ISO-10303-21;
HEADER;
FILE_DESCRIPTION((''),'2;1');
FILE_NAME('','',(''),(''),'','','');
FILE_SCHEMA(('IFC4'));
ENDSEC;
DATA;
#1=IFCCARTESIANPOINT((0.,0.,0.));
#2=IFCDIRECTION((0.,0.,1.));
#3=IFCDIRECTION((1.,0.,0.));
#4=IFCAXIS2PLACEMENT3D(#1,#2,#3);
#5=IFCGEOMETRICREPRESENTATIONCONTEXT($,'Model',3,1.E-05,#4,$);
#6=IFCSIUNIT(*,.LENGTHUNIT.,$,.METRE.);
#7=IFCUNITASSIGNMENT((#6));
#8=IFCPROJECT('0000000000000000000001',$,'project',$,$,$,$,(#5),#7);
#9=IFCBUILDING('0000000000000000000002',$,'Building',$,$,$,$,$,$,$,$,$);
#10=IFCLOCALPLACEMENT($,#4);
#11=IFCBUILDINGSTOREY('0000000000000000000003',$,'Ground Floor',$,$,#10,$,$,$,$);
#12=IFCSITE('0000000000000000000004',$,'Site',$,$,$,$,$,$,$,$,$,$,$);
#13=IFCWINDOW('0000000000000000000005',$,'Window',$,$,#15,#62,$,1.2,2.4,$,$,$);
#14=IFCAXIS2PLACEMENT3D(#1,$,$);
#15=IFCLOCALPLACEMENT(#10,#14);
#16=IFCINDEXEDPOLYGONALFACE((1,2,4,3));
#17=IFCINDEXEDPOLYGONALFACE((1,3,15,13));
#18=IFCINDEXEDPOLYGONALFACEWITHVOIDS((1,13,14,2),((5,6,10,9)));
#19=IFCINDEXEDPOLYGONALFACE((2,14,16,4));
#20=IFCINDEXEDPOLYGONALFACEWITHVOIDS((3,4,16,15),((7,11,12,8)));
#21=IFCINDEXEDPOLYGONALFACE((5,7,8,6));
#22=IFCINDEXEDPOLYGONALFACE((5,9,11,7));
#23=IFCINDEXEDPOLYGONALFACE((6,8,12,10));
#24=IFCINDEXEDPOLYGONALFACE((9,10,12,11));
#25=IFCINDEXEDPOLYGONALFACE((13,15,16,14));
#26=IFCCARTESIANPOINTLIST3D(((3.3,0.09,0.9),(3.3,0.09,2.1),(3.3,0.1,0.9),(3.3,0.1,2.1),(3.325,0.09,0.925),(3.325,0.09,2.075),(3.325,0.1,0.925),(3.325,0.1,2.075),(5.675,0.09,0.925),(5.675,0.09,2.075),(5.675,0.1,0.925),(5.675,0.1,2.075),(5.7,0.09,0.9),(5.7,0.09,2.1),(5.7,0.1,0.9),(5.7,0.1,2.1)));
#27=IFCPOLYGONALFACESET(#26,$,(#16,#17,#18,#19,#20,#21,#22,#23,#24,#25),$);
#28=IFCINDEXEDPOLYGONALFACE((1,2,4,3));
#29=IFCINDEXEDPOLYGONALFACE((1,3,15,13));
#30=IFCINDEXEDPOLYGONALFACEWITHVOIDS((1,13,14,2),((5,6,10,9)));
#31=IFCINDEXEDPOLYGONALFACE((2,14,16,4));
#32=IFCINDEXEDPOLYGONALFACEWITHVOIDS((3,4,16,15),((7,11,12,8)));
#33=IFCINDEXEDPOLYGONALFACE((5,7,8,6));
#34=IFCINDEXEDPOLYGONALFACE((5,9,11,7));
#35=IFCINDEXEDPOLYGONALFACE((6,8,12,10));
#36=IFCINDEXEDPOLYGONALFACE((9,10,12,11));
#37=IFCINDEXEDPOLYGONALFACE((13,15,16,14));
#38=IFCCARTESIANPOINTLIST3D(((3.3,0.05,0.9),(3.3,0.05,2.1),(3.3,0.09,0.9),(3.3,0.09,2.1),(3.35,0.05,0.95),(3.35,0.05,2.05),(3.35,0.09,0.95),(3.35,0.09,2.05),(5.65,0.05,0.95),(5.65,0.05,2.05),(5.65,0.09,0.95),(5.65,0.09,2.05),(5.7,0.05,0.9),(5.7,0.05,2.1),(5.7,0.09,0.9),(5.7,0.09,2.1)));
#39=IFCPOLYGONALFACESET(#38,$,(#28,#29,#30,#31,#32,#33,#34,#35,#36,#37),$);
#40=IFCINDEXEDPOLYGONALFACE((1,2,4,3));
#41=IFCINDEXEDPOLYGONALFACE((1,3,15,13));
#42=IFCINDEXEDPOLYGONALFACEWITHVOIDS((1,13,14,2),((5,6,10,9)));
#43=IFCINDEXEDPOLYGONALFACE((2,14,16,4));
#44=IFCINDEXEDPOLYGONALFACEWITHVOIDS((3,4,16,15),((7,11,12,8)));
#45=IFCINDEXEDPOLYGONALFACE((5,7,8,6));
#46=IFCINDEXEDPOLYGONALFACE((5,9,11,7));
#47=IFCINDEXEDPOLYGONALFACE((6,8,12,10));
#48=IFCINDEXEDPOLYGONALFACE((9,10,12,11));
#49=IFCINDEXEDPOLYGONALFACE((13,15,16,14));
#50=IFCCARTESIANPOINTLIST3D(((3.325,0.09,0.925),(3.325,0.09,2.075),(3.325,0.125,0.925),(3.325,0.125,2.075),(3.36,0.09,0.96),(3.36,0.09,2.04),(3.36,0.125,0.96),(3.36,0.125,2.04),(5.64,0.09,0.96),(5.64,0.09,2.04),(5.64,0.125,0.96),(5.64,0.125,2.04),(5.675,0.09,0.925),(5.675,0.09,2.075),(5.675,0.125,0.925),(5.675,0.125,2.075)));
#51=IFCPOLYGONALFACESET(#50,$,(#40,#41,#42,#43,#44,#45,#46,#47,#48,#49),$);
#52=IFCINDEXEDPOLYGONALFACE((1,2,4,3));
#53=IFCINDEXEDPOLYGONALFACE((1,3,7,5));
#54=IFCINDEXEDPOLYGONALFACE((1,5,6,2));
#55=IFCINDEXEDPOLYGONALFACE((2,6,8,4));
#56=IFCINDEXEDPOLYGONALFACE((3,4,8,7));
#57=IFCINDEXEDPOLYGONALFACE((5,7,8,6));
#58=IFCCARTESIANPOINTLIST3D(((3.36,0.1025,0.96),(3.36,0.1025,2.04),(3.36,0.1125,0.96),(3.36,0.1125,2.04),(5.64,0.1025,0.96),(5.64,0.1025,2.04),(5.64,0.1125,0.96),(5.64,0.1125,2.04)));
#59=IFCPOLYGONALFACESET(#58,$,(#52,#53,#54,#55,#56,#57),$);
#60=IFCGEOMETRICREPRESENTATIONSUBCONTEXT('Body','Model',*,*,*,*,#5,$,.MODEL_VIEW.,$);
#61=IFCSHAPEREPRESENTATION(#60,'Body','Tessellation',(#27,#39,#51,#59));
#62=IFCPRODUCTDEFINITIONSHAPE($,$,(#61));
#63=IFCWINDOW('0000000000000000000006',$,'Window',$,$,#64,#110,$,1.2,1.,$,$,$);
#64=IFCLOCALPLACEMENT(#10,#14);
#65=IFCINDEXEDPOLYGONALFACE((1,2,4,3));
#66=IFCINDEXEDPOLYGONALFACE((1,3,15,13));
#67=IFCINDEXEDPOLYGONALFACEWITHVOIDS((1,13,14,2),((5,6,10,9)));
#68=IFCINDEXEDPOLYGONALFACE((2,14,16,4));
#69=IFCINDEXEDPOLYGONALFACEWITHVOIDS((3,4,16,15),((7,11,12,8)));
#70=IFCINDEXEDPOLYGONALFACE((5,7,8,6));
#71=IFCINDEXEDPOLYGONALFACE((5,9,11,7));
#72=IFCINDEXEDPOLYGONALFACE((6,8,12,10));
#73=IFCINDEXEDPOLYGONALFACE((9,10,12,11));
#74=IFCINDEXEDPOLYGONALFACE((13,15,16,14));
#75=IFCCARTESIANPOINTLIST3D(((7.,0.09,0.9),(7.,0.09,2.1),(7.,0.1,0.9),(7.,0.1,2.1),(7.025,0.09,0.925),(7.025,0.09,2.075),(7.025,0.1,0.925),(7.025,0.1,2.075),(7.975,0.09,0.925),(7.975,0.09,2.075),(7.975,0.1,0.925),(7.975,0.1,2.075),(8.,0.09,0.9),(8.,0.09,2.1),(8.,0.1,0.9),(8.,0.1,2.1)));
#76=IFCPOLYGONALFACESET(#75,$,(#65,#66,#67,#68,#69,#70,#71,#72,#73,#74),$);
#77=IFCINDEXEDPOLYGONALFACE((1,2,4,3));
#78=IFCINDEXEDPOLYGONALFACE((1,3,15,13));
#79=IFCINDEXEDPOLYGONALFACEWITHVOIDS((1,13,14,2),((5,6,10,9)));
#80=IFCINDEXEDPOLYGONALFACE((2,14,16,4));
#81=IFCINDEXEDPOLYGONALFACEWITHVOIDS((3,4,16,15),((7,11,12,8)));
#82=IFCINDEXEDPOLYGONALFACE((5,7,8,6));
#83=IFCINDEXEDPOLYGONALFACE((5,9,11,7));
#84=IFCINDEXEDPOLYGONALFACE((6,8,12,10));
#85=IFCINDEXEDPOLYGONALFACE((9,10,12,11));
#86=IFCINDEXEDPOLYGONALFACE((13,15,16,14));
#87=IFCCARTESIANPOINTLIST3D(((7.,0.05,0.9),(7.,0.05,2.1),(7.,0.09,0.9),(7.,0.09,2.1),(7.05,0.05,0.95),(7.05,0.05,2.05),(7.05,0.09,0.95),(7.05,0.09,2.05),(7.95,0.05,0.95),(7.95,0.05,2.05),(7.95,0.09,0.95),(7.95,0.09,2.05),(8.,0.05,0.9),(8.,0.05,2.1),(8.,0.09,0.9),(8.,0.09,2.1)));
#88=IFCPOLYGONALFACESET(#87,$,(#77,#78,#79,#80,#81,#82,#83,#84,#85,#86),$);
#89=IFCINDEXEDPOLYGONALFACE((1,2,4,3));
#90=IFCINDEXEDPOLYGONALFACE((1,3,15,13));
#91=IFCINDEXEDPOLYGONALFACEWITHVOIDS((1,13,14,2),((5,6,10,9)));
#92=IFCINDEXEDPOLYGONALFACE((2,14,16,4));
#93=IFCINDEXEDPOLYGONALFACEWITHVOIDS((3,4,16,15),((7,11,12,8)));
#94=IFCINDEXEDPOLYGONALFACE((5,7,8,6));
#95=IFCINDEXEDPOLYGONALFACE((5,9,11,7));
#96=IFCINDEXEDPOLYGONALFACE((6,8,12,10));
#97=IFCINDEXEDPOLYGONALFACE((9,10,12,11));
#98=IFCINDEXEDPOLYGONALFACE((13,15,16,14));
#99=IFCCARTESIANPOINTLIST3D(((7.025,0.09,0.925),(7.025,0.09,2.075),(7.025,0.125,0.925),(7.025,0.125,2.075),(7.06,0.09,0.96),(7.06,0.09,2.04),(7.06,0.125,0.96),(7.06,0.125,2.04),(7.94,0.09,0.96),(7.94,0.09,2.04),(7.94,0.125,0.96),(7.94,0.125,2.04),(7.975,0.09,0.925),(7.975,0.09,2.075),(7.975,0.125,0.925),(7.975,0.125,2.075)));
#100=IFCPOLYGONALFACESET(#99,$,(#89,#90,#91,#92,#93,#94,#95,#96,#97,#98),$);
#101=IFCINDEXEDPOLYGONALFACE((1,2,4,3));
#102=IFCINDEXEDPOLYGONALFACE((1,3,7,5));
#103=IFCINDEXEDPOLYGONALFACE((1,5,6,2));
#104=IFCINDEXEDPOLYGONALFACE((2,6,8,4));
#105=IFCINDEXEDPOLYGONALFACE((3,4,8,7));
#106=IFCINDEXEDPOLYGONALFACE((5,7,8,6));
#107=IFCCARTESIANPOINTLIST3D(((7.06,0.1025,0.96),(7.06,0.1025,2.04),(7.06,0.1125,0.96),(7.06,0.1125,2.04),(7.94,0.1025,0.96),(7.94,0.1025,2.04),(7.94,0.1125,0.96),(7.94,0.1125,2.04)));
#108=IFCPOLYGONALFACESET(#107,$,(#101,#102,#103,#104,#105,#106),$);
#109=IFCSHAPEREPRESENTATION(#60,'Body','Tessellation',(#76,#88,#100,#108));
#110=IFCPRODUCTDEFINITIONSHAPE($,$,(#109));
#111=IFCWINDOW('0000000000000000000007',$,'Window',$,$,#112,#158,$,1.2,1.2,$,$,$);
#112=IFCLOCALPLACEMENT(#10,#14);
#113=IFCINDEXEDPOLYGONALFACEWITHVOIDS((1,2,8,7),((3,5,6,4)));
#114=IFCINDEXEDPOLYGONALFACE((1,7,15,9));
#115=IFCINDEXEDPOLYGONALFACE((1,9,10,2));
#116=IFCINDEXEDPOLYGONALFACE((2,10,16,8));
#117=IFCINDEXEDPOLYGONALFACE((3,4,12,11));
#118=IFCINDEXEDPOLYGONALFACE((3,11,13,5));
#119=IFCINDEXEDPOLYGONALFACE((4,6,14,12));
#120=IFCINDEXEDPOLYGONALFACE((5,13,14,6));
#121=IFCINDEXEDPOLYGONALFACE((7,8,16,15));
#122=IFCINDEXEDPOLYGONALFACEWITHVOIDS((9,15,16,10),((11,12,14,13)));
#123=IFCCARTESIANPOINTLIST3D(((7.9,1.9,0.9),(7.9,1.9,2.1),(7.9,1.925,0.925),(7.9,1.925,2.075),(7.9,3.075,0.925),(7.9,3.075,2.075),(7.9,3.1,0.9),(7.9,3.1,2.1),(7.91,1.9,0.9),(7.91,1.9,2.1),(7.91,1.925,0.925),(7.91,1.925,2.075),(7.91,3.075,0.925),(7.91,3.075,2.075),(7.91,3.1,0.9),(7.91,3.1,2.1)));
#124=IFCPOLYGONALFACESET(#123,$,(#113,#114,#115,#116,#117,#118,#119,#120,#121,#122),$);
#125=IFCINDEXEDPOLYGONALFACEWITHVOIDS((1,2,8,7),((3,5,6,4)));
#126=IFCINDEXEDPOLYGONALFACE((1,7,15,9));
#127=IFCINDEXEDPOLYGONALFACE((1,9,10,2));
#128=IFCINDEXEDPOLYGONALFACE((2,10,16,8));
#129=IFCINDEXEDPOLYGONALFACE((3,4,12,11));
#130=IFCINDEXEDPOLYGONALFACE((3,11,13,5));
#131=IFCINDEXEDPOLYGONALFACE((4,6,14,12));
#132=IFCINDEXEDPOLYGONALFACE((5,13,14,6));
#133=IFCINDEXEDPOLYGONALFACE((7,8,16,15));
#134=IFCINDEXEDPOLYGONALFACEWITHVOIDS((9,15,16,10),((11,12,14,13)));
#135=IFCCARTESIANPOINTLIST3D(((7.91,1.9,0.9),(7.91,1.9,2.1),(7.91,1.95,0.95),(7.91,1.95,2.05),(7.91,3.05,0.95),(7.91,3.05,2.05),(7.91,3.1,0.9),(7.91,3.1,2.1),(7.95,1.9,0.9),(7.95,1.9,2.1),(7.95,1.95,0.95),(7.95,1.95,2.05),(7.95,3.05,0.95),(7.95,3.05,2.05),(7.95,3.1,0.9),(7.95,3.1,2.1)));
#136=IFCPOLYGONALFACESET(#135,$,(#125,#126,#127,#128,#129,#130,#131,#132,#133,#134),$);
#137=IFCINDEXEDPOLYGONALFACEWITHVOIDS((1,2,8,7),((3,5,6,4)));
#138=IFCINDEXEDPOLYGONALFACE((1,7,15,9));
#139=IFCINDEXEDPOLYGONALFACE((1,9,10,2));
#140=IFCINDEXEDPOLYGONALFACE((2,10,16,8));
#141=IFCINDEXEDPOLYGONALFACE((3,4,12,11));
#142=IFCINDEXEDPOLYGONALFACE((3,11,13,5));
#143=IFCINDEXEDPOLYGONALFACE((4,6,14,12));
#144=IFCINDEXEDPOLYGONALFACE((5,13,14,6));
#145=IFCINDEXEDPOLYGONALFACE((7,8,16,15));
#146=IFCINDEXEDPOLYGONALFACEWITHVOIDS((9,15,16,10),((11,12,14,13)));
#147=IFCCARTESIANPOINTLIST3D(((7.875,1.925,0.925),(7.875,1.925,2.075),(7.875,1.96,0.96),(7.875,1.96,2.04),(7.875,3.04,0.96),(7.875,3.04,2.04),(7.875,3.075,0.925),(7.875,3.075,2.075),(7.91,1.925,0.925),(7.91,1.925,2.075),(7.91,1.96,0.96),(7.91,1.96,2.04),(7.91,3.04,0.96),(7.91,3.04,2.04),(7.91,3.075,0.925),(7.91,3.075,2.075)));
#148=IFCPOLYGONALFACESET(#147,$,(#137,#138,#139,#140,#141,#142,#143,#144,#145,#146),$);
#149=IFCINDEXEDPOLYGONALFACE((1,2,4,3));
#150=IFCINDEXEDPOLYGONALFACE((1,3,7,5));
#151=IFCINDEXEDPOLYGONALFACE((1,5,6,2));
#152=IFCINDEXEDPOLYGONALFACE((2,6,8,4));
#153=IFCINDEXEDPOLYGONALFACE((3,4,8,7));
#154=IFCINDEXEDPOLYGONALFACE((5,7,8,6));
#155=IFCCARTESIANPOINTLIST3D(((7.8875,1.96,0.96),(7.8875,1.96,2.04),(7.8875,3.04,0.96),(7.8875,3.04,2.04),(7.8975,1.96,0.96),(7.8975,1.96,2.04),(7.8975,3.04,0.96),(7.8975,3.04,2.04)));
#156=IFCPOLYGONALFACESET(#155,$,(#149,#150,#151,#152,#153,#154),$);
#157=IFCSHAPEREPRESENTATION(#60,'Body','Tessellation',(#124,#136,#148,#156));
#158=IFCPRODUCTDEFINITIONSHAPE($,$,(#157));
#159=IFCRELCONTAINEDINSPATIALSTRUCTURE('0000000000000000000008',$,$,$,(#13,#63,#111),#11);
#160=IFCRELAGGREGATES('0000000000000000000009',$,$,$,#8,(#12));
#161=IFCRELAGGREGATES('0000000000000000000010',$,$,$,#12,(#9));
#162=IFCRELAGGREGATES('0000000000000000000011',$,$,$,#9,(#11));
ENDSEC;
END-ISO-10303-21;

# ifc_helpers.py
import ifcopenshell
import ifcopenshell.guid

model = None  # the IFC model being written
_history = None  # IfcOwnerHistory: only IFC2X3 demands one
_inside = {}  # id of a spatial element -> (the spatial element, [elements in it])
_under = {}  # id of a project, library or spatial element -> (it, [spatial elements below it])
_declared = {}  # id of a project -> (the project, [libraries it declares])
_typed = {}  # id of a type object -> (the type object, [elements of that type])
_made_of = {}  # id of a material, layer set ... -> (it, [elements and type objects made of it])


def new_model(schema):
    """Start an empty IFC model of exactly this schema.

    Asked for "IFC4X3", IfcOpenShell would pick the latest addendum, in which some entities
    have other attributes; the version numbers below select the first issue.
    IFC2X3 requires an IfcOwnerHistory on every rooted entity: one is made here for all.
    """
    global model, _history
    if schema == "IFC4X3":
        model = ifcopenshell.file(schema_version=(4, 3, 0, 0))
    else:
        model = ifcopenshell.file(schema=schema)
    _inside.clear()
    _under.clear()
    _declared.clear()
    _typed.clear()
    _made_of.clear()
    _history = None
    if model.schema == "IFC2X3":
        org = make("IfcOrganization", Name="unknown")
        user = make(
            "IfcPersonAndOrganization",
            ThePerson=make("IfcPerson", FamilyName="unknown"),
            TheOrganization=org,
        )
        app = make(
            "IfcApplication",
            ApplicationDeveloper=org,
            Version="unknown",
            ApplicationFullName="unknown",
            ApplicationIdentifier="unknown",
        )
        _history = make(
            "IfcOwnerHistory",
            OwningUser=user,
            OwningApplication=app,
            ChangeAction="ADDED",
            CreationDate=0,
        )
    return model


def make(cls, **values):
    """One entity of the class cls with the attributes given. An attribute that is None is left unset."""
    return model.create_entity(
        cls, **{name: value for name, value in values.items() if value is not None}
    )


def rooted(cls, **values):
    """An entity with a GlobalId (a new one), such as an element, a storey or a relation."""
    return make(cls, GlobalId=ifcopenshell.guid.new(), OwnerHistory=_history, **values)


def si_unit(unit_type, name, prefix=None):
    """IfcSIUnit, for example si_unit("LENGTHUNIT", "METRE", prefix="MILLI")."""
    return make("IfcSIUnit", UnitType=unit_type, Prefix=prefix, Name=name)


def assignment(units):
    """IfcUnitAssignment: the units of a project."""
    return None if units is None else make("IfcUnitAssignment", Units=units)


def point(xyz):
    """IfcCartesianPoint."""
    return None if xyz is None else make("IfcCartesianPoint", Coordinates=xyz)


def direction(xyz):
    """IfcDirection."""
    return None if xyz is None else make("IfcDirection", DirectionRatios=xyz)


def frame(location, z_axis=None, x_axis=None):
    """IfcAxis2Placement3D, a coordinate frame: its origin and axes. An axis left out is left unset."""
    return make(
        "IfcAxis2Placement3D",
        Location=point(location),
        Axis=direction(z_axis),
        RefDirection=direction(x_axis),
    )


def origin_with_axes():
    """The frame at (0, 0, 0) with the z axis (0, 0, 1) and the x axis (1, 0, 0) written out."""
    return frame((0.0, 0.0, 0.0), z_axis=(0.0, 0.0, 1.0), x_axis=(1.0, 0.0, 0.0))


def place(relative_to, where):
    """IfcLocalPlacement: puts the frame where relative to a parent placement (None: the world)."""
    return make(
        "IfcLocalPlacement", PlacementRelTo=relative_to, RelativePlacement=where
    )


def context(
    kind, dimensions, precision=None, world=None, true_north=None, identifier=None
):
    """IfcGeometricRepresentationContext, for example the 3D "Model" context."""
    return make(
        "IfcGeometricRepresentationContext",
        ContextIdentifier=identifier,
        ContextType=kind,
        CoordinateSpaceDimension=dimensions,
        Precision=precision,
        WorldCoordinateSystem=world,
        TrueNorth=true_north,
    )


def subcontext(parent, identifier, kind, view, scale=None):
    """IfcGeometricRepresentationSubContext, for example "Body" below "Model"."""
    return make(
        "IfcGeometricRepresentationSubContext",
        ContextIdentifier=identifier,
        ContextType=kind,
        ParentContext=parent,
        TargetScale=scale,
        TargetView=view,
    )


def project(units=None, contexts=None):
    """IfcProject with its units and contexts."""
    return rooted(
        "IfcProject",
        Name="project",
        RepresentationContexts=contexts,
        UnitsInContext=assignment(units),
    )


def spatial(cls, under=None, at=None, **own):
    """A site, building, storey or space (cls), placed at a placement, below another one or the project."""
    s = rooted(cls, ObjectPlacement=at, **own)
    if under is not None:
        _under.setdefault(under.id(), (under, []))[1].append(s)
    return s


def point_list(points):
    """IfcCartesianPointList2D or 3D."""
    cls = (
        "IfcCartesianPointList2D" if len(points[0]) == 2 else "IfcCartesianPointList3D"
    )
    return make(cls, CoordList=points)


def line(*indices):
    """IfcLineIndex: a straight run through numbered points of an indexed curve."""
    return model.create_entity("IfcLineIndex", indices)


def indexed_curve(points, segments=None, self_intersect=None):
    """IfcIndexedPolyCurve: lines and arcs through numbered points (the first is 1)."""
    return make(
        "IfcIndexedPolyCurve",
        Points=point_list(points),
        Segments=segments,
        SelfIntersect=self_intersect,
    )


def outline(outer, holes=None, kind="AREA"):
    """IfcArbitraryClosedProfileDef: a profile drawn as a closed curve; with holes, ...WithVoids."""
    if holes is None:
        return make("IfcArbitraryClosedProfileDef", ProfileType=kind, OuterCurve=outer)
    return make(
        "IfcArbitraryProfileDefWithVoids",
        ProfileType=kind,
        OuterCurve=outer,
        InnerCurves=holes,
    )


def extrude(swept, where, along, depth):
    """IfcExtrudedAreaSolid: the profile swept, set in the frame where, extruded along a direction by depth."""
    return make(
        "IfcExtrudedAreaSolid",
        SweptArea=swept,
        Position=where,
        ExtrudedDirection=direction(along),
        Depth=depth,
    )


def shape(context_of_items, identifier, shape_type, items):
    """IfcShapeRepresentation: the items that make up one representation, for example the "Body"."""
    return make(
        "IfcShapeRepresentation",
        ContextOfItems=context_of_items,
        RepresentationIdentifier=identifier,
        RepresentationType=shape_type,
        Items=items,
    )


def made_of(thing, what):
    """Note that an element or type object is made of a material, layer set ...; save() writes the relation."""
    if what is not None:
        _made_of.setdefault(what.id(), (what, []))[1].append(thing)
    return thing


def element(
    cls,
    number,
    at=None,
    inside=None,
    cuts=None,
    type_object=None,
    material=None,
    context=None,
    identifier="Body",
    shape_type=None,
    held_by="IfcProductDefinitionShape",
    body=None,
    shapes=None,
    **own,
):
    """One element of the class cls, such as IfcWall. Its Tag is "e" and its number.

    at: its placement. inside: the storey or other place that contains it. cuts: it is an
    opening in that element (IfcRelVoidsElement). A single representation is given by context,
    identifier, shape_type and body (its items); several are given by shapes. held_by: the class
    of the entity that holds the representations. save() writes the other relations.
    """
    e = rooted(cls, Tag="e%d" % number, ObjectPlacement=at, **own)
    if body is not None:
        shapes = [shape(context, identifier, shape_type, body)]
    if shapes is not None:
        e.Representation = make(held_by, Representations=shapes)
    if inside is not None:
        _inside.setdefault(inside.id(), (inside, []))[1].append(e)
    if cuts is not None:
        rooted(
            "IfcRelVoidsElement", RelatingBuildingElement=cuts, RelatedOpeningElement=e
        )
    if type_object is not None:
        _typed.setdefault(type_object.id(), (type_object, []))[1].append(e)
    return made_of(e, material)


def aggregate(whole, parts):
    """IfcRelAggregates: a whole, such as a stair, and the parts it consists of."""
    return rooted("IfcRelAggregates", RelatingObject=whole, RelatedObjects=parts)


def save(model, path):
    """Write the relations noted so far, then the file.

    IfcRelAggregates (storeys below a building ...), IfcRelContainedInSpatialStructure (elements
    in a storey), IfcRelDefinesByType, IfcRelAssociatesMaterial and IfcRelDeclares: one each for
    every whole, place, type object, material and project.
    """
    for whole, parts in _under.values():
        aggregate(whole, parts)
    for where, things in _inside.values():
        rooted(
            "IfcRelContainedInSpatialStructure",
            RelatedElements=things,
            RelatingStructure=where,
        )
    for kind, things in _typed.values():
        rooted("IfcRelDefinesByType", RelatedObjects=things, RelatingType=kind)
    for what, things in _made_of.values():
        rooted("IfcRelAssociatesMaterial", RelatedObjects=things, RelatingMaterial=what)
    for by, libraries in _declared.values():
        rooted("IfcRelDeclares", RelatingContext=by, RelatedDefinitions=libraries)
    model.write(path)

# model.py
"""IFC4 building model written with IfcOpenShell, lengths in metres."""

from ifc_helpers import new_model, si_unit, frame, origin_with_axes, place, context, subcontext, project, spatial, line, indexed_curve, outline, extrude, element, save


model = new_model("IFC4")

# Units and contexts
model_context = context("Model", 3, precision=1e-05, world=origin_with_axes())
body_context = subcontext(model_context, "Body", "Model", "MODEL_VIEW")
ifc_project = project(units=[si_unit("LENGTHUNIT", "METRE")], contexts=[model_context])

# Site, building, storey
site = spatial("IfcSite", under=ifc_project, Name="Site")
building = spatial("IfcBuilding", under=site, Name="Building")
storey_placement = place(None, origin_with_axes())
storey = spatial("IfcBuildingStorey", under=building, at=storey_placement, Name="Ground Floor")

# Windows
window_1_placement = place(storey_placement, frame((3.3, 0.0, 0.9), z_axis=(0.0, 0.0, 1.0), x_axis=(1.0, 0.0, 0.0)))
element("IfcWindow", 1, at=window_1_placement, inside=storey, Name="Window", OverallHeight=1.2, OverallWidth=2.4, context=body_context, shape_type="SweptSolid", body=[
    extrude(outline(indexed_curve([(0.0, 0.0), (2.4, 0.0), (2.4, 1.2), (0.0, 1.2)], segments=[line(1, 2, 3, 4, 1)]), holes=[indexed_curve([(0.025, 0.025), (2.375, 0.025), (2.375, 1.175), (0.025, 1.175)], segments=[line(1, 2, 3, 4, 1)])]), frame((0.0, 0.09, 0.0), z_axis=(0.0, -1.0, 0.0), x_axis=(1.0, 0.0, 0.0)), (0.0, 0.0, -1.0), 0.01),
    extrude(outline(indexed_curve([(0.0, 0.0), (2.4, 0.0), (2.4, 1.2), (0.0, 1.2)], segments=[line(1, 2, 3, 4, 1)]), holes=[indexed_curve([(0.05, 0.05), (2.35, 0.05), (2.35, 1.15), (0.05, 1.15)], segments=[line(1, 2, 3, 4, 1)])]), frame((0.0, 0.05, 0.0), z_axis=(0.0, -1.0, 0.0), x_axis=(1.0, 0.0, 0.0)), (0.0, 0.0, -1.0), 0.04),
    extrude(outline(indexed_curve([(0.0, 0.0), (2.35, 0.0), (2.35, 1.15), (0.0, 1.15)], segments=[line(1, 2, 3, 4, 1)]), holes=[indexed_curve([(0.035, 0.035), (2.315, 0.035), (2.315, 1.115), (0.035, 1.115)], segments=[line(1, 2, 3, 4, 1)])]), frame((0.025, 0.09, 0.025), z_axis=(0.0, -1.0, 0.0), x_axis=(1.0, 0.0, 0.0)), (0.0, 0.0, -1.0), 0.035),
    extrude(outline(indexed_curve([(0.035, 0.035), (2.315, 0.035), (2.315, 1.115), (0.035, 1.115)], segments=[line(1, 2, 3, 4, 1)])), frame((0.025, 0.1025, 0.025), z_axis=(0.0, -1.0, 0.0), x_axis=(1.0, 0.0, 0.0)), (0.0, 0.0, -1.0), 0.01),
])
window_2_placement = place(storey_placement, frame((7.0, 0.0, 0.9), z_axis=(0.0, 0.0, 1.0), x_axis=(1.0, 0.0, 0.0)))
element("IfcWindow", 2, at=window_2_placement, inside=storey, Name="Window", OverallHeight=1.2, OverallWidth=1.0, context=body_context, shape_type="SweptSolid", body=[
    extrude(outline(indexed_curve([(0.0, 0.0), (1.0, 0.0), (1.0, 1.2), (0.0, 1.2)], segments=[line(1, 2, 3, 4, 1)]), holes=[indexed_curve([(0.025, 0.025), (0.975, 0.025), (0.975, 1.175), (0.025, 1.175)], segments=[line(1, 2, 3, 4, 1)])]), frame((0.0, 0.09, 0.0), z_axis=(0.0, -1.0, 0.0), x_axis=(1.0, 0.0, 0.0)), (0.0, 0.0, -1.0), 0.01),
    extrude(outline(indexed_curve([(0.0, 0.0), (1.0, 0.0), (1.0, 1.2), (0.0, 1.2)], segments=[line(1, 2, 3, 4, 1)]), holes=[indexed_curve([(0.05, 0.05), (0.95, 0.05), (0.95, 1.15), (0.05, 1.15)], segments=[line(1, 2, 3, 4, 1)])]), frame((0.0, 0.05, 0.0), z_axis=(0.0, -1.0, 0.0), x_axis=(1.0, 0.0, 0.0)), (0.0, 0.0, -1.0), 0.04),
    extrude(outline(indexed_curve([(0.0, 0.0), (0.95, 0.0), (0.95, 1.15), (0.0, 1.15)], segments=[line(1, 2, 3, 4, 1)]), holes=[indexed_curve([(0.035, 0.035), (0.915, 0.035), (0.915, 1.115), (0.035, 1.115)], segments=[line(1, 2, 3, 4, 1)])]), frame((0.025, 0.09, 0.025), z_axis=(0.0, -1.0, 0.0), x_axis=(1.0, 0.0, 0.0)), (0.0, 0.0, -1.0), 0.035),
    extrude(outline(indexed_curve([(0.035, 0.035), (0.915, 0.035), (0.915, 1.115), (0.035, 1.115)], segments=[line(1, 2, 3, 4, 1)])), frame((0.025, 0.1025, 0.025), z_axis=(0.0, -1.0, 0.0), x_axis=(1.0, 0.0, 0.0)), (0.0, 0.0, -1.0), 0.01),
])
window_3_placement = place(storey_placement, frame((8.0, 1.9, 0.9), z_axis=(0.0, 0.0, 1.0), x_axis=(0.0, 1.0, 0.0)))
element("IfcWindow", 3, at=window_3_placement, inside=storey, Name="Window", OverallHeight=1.2, OverallWidth=1.2, context=body_context, shape_type="SweptSolid", body=[
    extrude(outline(indexed_curve([(0.0, 0.0), (1.2, 0.0), (1.2, 1.2), (0.0, 1.2)], segments=[line(1, 2, 3, 4, 1)]), holes=[indexed_curve([(0.025, 0.025), (1.175, 0.025), (1.175, 1.175), (0.025, 1.175)], segments=[line(1, 2, 3, 4, 1)])]), frame((0.0, 0.09, 0.0), z_axis=(0.0, -1.0, 0.0), x_axis=(1.0, 0.0, 0.0)), (0.0, 0.0, -1.0), 0.01),
    extrude(outline(indexed_curve([(0.0, 0.0), (1.2, 0.0), (1.2, 1.2), (0.0, 1.2)], segments=[line(1, 2, 3, 4, 1)]), holes=[indexed_curve([(0.05, 0.05), (1.15, 0.05), (1.15, 1.15), (0.05, 1.15)], segments=[line(1, 2, 3, 4, 1)])]), frame((0.0, 0.05, 0.0), z_axis=(0.0, -1.0, 0.0), x_axis=(1.0, 0.0, 0.0)), (0.0, 0.0, -1.0), 0.04),
    extrude(outline(indexed_curve([(0.0, 0.0), (1.15, 0.0), (1.15, 1.15), (0.0, 1.15)], segments=[line(1, 2, 3, 4, 1)]), holes=[indexed_curve([(0.035, 0.035), (1.115, 0.035), (1.115, 1.115), (0.035, 1.115)], segments=[line(1, 2, 3, 4, 1)])]), frame((0.025, 0.09, 0.025), z_axis=(0.0, -1.0, 0.0), x_axis=(1.0, 0.0, 0.0)), (0.0, 0.0, -1.0), 0.035),
    extrude(outline(indexed_curve([(0.035, 0.035), (1.115, 0.035), (1.115, 1.115), (0.035, 1.115)], segments=[line(1, 2, 3, 4, 1)])), frame((0.025, 0.1025, 0.025), z_axis=(0.0, -1.0, 0.0), x_axis=(1.0, 0.0, 0.0)), (0.0, 0.0, -1.0), 0.01),
])

save(model, "model.ifc")
